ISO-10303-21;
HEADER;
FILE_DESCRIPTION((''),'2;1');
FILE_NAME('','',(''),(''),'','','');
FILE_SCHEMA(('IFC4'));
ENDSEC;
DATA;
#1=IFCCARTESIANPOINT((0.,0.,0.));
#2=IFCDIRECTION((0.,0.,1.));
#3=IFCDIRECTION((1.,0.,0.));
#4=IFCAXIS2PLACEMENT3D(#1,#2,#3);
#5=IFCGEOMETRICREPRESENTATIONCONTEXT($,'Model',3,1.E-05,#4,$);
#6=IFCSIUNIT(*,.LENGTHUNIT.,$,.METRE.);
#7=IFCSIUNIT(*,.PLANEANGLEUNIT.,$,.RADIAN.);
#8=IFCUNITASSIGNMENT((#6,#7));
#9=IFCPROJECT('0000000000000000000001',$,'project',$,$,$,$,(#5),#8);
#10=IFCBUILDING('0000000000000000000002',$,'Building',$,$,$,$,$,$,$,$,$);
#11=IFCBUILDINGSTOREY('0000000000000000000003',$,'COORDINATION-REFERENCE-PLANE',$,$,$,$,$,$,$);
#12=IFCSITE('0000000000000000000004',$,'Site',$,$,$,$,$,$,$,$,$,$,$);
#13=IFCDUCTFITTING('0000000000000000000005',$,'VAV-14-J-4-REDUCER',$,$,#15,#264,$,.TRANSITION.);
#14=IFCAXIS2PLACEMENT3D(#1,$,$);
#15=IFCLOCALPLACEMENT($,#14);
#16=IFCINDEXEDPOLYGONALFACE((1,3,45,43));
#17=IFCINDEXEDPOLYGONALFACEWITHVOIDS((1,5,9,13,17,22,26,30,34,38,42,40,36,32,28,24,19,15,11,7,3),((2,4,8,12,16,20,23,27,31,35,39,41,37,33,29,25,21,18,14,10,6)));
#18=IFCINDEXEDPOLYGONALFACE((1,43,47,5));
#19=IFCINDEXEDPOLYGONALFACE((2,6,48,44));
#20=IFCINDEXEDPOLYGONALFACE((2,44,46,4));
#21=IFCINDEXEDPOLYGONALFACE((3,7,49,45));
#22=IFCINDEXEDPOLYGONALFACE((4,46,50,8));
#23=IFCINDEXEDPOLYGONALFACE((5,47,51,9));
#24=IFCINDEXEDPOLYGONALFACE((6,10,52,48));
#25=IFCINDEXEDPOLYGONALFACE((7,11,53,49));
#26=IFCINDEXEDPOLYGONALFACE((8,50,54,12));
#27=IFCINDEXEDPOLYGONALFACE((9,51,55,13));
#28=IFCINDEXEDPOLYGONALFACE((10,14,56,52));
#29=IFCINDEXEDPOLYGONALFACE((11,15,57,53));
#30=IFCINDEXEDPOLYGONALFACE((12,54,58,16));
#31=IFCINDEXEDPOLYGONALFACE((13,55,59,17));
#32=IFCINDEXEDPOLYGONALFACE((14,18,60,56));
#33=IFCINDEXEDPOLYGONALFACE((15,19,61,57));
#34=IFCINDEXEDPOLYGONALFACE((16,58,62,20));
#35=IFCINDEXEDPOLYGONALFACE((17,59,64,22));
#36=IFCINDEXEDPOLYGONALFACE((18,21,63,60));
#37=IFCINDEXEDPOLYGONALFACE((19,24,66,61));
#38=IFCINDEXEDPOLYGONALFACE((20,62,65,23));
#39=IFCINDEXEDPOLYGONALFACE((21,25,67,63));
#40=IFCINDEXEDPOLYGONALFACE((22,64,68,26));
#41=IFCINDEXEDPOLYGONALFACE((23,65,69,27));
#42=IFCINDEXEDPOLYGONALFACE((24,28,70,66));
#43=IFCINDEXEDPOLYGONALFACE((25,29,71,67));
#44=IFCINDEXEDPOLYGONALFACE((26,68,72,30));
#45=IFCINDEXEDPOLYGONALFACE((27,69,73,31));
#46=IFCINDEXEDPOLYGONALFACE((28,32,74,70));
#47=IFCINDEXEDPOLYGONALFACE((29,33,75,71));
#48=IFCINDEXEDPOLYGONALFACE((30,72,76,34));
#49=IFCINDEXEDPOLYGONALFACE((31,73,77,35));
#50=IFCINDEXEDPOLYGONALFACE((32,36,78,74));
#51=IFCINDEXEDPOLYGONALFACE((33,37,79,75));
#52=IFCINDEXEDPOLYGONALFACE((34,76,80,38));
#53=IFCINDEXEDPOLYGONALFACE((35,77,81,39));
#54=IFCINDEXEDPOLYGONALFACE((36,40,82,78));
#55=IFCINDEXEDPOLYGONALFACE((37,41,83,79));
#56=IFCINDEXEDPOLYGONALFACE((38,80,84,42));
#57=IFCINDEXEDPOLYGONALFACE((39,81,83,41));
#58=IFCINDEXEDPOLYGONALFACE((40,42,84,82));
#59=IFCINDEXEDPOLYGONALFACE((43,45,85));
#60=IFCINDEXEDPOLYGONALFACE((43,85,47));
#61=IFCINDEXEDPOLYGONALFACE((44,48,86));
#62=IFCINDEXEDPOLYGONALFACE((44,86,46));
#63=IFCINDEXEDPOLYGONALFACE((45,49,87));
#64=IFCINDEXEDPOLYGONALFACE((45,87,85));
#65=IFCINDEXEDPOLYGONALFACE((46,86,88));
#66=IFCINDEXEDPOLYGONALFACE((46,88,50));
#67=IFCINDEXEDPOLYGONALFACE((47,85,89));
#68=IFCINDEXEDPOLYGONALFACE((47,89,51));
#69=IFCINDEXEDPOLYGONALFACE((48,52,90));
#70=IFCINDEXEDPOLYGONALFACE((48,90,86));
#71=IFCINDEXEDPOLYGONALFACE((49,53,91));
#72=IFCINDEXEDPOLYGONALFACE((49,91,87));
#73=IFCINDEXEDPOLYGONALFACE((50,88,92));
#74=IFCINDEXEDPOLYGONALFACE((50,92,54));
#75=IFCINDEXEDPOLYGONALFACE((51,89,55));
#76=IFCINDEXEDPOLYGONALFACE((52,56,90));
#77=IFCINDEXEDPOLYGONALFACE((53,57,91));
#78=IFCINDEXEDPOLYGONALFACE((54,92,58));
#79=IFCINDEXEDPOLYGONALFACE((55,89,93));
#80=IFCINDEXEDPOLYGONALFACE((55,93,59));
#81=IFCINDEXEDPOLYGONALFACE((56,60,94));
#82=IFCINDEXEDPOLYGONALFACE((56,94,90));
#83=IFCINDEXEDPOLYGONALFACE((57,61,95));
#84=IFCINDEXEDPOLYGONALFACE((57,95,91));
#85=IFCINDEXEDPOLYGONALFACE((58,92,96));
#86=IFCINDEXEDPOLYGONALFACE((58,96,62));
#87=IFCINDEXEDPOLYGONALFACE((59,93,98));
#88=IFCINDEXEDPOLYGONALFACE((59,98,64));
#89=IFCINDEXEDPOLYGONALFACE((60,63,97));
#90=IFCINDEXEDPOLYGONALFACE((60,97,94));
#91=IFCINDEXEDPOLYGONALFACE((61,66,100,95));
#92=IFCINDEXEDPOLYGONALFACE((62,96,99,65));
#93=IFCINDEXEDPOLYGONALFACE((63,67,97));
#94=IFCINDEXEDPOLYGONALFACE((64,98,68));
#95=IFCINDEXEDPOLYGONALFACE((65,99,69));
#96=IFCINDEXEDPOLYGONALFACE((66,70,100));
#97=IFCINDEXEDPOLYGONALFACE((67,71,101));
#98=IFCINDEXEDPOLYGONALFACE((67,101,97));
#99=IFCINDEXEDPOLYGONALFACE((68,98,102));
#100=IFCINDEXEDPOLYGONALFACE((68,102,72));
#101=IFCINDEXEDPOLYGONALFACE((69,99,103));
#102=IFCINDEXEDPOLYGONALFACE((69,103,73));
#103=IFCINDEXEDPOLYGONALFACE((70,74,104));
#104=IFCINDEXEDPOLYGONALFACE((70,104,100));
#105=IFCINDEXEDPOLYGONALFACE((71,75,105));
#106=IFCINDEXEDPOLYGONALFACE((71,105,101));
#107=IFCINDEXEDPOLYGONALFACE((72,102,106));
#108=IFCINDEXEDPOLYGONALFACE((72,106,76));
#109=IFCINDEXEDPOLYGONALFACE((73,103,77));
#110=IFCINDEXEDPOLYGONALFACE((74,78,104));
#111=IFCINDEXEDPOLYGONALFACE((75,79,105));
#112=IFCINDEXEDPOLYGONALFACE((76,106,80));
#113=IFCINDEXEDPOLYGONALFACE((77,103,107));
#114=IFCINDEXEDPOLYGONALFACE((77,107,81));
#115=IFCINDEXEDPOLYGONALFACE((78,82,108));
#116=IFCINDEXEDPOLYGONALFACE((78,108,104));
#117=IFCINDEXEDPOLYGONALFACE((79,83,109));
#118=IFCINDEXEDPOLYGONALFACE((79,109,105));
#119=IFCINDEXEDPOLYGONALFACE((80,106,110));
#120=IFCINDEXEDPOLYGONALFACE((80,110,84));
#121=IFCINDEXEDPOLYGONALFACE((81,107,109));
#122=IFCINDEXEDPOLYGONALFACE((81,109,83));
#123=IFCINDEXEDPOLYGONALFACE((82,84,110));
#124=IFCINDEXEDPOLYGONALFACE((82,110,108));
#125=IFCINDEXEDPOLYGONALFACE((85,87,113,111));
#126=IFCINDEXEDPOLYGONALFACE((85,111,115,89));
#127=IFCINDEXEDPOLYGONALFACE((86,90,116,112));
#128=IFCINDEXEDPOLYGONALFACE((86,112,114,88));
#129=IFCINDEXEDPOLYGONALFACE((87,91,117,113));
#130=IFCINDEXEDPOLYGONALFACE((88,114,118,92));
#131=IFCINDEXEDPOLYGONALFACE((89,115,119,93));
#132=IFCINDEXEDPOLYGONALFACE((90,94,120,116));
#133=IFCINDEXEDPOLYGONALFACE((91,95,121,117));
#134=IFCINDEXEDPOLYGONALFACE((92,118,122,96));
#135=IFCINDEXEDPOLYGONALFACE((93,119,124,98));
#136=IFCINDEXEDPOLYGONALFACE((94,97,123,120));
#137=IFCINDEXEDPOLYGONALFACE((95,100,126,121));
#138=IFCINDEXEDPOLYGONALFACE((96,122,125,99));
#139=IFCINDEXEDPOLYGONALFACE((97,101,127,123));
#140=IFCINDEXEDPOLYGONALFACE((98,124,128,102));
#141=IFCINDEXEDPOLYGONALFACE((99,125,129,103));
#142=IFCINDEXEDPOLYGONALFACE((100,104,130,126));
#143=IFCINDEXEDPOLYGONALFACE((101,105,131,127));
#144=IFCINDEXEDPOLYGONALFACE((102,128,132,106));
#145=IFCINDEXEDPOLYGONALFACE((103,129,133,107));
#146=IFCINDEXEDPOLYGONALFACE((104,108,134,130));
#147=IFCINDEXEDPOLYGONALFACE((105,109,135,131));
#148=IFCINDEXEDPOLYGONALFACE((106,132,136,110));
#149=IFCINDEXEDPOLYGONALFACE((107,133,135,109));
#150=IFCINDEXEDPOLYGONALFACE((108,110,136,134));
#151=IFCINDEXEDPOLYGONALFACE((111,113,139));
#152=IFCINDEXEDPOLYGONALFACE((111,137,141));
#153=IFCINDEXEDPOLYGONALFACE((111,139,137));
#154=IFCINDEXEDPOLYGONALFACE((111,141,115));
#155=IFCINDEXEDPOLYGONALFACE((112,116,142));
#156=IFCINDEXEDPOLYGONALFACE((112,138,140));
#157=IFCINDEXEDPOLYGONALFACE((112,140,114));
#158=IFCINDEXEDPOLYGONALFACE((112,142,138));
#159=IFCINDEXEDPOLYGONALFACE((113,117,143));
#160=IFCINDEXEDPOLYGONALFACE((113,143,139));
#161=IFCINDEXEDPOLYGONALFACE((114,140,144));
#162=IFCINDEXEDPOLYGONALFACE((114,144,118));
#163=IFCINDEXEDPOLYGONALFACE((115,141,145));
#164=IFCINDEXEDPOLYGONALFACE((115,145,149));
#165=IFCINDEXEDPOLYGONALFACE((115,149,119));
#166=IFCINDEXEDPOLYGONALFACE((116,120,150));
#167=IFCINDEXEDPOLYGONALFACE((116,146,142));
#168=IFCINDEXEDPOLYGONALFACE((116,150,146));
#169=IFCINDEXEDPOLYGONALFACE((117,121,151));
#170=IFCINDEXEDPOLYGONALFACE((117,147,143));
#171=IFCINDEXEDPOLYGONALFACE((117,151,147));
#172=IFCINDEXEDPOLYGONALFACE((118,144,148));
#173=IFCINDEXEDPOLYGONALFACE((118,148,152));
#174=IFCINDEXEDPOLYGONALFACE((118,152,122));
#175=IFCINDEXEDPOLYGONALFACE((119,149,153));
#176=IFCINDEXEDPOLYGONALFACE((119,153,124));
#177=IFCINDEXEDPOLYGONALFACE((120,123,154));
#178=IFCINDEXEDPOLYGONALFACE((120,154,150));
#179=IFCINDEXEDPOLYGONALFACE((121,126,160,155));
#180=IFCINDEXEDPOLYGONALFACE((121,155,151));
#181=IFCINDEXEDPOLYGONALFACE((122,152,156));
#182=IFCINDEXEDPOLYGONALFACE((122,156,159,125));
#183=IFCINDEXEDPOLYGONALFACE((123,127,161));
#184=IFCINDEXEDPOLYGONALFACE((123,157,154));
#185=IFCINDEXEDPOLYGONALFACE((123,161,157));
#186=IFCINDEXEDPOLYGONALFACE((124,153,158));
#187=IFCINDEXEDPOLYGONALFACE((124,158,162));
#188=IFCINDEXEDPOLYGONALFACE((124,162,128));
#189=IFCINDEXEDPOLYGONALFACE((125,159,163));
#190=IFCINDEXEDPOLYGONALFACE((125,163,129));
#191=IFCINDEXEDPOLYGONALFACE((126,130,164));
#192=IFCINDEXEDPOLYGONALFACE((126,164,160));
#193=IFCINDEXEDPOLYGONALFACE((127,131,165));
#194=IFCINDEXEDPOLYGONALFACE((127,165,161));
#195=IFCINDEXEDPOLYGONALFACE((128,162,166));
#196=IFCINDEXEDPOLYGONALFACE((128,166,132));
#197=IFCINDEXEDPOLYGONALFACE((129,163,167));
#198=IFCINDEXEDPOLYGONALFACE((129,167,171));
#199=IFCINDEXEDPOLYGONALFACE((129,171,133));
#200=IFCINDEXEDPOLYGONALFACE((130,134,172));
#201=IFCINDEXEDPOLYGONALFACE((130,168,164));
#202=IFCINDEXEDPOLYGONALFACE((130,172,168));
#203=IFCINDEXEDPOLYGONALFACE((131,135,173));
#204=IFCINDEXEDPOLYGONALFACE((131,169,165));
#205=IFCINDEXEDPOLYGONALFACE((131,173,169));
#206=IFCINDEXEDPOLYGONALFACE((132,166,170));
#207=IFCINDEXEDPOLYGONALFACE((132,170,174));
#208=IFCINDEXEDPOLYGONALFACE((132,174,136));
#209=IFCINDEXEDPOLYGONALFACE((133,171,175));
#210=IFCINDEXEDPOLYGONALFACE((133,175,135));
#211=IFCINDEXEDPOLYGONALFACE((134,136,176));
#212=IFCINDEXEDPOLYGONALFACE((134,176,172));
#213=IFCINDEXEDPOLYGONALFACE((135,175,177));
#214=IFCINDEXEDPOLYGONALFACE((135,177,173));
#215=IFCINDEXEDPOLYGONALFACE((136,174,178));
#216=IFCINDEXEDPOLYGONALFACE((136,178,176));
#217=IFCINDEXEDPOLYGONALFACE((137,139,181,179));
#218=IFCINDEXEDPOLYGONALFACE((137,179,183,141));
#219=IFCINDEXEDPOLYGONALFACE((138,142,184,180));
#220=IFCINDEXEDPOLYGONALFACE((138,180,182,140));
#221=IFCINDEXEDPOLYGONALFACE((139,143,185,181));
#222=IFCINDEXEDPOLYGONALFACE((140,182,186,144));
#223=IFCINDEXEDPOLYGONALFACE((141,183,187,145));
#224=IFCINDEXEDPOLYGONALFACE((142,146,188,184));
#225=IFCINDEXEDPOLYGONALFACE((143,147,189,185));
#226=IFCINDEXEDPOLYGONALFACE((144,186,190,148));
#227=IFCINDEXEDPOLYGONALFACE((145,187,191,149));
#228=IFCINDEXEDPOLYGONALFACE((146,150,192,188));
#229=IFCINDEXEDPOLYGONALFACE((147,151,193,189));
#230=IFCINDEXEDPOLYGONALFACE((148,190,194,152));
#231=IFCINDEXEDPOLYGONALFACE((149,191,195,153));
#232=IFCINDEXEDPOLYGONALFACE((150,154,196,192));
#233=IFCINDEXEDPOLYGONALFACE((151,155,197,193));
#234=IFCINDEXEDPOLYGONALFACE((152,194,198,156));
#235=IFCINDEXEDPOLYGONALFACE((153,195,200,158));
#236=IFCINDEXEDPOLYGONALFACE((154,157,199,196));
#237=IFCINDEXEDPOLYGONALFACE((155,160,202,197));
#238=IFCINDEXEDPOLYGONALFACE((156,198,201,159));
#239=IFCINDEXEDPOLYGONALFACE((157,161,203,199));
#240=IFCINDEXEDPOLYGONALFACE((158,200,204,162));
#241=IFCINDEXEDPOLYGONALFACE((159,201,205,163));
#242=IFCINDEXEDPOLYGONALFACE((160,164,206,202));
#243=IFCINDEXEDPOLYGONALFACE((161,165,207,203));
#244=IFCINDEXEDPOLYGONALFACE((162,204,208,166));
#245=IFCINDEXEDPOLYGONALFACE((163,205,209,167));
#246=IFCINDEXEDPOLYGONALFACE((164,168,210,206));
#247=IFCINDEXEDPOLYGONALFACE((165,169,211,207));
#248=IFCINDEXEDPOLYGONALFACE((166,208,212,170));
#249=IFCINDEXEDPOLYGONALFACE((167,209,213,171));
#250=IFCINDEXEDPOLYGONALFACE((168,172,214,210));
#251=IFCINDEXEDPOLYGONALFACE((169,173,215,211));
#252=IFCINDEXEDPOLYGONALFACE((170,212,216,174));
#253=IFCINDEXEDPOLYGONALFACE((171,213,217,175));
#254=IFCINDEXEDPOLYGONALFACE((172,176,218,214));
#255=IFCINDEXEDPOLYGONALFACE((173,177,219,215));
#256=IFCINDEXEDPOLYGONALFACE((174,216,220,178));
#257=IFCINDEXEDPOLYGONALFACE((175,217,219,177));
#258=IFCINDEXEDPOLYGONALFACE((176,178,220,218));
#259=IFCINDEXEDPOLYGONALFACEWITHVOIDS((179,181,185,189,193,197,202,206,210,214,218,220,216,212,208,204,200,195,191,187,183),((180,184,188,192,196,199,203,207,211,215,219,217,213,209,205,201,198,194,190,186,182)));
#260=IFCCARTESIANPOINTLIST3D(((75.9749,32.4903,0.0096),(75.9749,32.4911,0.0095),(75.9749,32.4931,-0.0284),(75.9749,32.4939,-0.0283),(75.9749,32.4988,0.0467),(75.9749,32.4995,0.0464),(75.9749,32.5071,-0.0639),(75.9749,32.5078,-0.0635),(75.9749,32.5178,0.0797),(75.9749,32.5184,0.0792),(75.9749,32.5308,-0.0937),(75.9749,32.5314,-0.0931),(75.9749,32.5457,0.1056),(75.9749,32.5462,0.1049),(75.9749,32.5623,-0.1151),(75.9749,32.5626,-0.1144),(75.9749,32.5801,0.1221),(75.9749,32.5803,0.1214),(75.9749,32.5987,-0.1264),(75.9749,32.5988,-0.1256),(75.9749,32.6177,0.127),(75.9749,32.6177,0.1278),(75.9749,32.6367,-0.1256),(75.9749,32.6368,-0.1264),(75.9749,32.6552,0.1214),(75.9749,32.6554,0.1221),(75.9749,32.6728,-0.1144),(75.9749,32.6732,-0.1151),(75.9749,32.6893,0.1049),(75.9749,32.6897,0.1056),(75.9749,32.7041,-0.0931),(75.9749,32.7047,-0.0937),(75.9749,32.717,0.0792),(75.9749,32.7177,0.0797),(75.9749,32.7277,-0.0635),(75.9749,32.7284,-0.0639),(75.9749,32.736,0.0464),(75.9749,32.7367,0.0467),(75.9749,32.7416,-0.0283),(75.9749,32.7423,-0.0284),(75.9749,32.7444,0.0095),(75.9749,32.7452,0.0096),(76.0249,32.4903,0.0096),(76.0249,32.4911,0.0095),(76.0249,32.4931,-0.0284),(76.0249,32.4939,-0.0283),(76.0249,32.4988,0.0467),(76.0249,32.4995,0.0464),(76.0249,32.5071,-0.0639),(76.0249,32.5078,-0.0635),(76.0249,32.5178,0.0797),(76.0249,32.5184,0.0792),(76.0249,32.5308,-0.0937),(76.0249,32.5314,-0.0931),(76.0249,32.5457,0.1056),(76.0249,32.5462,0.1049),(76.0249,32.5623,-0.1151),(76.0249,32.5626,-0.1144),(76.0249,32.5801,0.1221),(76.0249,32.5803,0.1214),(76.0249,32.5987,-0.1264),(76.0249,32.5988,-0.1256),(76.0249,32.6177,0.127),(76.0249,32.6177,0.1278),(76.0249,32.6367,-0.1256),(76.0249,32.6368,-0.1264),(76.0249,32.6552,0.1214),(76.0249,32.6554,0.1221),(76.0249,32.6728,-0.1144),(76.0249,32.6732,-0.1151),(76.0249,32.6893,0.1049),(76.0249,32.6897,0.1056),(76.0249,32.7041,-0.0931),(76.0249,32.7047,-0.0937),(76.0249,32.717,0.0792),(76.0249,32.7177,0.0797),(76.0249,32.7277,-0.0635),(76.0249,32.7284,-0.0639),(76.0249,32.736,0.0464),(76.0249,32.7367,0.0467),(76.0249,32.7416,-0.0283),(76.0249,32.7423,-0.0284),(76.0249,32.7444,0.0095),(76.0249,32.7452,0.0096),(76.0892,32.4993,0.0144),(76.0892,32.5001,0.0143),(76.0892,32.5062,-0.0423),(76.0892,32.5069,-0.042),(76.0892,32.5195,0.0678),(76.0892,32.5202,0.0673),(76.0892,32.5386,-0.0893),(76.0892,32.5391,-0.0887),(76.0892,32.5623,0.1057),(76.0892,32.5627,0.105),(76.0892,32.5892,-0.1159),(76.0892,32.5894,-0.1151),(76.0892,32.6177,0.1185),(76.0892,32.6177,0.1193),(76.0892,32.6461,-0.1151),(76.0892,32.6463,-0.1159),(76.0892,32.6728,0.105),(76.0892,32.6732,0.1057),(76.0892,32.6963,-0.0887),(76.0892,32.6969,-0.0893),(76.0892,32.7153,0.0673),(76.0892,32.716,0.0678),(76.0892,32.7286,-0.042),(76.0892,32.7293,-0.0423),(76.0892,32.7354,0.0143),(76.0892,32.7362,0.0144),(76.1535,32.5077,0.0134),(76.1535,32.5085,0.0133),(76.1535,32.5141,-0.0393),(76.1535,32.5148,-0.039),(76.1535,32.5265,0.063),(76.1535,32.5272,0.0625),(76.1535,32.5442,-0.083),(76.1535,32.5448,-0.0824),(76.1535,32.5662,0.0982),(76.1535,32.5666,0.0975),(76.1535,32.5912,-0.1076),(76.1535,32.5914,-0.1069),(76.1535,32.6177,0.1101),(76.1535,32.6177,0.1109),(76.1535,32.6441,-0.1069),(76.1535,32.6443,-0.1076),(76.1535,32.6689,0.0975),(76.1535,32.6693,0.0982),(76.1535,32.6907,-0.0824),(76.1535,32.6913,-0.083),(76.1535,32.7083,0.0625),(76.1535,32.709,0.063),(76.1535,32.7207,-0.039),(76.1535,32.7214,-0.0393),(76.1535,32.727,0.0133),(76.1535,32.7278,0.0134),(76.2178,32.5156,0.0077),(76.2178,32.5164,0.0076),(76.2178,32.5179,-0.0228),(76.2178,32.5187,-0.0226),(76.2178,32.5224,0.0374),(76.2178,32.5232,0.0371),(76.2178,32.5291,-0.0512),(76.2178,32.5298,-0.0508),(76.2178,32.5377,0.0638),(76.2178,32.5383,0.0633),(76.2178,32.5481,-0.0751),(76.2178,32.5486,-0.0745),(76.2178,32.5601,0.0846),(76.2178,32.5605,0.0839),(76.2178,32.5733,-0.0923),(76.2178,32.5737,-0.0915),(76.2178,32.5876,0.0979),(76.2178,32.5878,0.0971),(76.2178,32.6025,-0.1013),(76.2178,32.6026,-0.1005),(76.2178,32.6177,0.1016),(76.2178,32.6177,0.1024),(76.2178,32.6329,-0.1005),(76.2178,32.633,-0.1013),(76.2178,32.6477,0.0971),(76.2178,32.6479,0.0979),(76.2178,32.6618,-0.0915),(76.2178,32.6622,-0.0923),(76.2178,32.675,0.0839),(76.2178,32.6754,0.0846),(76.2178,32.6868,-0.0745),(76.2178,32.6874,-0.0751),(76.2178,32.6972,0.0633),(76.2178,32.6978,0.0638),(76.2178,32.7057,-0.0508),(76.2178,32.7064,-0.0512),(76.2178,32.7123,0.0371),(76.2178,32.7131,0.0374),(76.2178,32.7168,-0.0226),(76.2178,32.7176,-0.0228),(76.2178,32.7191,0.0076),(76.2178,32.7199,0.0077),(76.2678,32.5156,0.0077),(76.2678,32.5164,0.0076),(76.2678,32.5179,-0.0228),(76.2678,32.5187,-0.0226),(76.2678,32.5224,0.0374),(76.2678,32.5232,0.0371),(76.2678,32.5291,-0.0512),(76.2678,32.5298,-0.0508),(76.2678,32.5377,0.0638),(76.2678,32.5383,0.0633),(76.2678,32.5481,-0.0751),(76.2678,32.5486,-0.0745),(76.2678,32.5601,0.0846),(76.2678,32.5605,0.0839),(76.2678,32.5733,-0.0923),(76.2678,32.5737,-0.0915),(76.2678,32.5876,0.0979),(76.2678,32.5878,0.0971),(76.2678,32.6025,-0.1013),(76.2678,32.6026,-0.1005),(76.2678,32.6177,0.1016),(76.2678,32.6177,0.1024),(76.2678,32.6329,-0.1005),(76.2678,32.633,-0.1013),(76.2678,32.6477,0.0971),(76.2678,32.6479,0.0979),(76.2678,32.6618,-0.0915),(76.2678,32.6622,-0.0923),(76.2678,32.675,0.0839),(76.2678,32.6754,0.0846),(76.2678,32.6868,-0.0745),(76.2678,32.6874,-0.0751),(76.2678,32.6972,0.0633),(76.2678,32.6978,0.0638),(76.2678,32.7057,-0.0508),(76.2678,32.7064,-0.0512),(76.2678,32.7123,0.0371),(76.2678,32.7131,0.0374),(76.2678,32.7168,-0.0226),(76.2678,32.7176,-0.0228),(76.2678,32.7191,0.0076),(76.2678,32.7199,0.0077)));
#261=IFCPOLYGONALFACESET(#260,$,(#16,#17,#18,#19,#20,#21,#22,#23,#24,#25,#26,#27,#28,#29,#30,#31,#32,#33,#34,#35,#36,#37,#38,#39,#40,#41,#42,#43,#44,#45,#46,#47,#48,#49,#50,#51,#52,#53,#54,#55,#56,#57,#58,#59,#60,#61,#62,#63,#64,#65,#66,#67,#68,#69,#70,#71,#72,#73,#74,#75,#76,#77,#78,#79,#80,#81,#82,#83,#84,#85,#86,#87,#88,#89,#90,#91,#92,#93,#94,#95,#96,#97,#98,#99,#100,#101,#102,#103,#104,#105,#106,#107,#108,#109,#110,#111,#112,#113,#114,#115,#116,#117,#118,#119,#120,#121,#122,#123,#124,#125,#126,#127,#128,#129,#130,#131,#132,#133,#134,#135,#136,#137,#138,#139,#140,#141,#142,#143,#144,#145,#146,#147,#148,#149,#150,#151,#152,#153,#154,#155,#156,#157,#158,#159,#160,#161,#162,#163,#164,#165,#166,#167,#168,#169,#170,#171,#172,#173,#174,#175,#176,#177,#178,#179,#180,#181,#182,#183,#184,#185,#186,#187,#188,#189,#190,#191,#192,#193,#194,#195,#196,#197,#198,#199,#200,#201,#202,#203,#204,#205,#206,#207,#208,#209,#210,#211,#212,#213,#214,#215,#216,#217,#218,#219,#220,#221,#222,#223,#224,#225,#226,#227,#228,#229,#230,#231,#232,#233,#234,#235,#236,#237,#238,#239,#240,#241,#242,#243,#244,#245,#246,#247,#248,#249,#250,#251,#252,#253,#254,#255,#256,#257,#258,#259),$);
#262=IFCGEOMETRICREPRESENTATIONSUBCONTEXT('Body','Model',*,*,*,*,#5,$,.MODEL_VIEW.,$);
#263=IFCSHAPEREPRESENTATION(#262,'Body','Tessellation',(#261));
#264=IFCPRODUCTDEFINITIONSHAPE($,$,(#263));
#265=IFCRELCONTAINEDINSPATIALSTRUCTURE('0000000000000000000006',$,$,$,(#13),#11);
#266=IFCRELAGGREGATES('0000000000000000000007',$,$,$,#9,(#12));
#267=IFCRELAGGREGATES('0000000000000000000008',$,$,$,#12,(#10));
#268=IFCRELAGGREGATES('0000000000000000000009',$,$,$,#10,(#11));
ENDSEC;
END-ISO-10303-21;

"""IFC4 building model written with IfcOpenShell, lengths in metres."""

from ifc_helpers import new_model, entity, si_unit, frame, origin_with_axes, place, context, subcontext, project, spatial, element, save


model = new_model("IFC4")

# Units and contexts
model_context = context("Model", 3, precision=1e-05, world=origin_with_axes())
body_context_1 = subcontext(model_context, "Body", "Model", "MODEL_VIEW")
ifc_project = project(units=[si_unit("LENGTHUNIT", "METRE"), si_unit("PLANEANGLEUNIT", "RADIAN")], contexts=[model_context])

# Site, building, storey
site = spatial("IfcSite", under=ifc_project, Name="Site")
building = spatial("IfcBuilding", under=site, Name="Building")
storey = spatial("IfcBuildingStorey", under=building, Name="COORDINATION-REFERENCE-PLANE")

# Duct fitting
for number, where, z_axis, x_axis, name in (
    (1, (75.9749, 32.6177, 0.0), (0.0, 1.0, 0.0), (0.0, 0.0, 1.0), "VAV-14-J-4-REDUCER"),
):
    element("IfcDuctFitting", number, at=place(None, frame(where, z_axis=z_axis, x_axis=x_axis)), inside=storey, Name=name, PredefinedType="TRANSITION", context=body_context_1, shape_type="SweptSolid", body=[
        entity("IfcRevolvedAreaSolid", entity("IfcArbitraryClosedProfileDef", "AREA", None, entity("IfcPolyline", [entity("IfcCartesianPoint", [0.1278, 0.0]), entity("IfcCartesianPoint", [0.1278, 0.05]), entity("IfcCartesianPoint", [0.1024, 0.2429]), entity("IfcCartesianPoint", [0.1024, 0.2929]), entity("IfcCartesianPoint", [0.1016, 0.2929]), entity("IfcCartesianPoint", [0.1016, 0.2429]), entity("IfcCartesianPoint", [0.127, 0.05]), entity("IfcCartesianPoint", [0.127, 0.0]), entity("IfcCartesianPoint", [0.1278, 0.0])])), entity("IfcAxis2Placement3D", entity("IfcCartesianPoint", [0.0, 0.0, 0.0])), entity("IfcAxis1Placement", entity("IfcCartesianPoint", [0.0, 0.0, 0.0]), entity("IfcDirection", [0.0, 1.0, 0.0])), 6.283185),
    ])

save(model, "model.ifc")
